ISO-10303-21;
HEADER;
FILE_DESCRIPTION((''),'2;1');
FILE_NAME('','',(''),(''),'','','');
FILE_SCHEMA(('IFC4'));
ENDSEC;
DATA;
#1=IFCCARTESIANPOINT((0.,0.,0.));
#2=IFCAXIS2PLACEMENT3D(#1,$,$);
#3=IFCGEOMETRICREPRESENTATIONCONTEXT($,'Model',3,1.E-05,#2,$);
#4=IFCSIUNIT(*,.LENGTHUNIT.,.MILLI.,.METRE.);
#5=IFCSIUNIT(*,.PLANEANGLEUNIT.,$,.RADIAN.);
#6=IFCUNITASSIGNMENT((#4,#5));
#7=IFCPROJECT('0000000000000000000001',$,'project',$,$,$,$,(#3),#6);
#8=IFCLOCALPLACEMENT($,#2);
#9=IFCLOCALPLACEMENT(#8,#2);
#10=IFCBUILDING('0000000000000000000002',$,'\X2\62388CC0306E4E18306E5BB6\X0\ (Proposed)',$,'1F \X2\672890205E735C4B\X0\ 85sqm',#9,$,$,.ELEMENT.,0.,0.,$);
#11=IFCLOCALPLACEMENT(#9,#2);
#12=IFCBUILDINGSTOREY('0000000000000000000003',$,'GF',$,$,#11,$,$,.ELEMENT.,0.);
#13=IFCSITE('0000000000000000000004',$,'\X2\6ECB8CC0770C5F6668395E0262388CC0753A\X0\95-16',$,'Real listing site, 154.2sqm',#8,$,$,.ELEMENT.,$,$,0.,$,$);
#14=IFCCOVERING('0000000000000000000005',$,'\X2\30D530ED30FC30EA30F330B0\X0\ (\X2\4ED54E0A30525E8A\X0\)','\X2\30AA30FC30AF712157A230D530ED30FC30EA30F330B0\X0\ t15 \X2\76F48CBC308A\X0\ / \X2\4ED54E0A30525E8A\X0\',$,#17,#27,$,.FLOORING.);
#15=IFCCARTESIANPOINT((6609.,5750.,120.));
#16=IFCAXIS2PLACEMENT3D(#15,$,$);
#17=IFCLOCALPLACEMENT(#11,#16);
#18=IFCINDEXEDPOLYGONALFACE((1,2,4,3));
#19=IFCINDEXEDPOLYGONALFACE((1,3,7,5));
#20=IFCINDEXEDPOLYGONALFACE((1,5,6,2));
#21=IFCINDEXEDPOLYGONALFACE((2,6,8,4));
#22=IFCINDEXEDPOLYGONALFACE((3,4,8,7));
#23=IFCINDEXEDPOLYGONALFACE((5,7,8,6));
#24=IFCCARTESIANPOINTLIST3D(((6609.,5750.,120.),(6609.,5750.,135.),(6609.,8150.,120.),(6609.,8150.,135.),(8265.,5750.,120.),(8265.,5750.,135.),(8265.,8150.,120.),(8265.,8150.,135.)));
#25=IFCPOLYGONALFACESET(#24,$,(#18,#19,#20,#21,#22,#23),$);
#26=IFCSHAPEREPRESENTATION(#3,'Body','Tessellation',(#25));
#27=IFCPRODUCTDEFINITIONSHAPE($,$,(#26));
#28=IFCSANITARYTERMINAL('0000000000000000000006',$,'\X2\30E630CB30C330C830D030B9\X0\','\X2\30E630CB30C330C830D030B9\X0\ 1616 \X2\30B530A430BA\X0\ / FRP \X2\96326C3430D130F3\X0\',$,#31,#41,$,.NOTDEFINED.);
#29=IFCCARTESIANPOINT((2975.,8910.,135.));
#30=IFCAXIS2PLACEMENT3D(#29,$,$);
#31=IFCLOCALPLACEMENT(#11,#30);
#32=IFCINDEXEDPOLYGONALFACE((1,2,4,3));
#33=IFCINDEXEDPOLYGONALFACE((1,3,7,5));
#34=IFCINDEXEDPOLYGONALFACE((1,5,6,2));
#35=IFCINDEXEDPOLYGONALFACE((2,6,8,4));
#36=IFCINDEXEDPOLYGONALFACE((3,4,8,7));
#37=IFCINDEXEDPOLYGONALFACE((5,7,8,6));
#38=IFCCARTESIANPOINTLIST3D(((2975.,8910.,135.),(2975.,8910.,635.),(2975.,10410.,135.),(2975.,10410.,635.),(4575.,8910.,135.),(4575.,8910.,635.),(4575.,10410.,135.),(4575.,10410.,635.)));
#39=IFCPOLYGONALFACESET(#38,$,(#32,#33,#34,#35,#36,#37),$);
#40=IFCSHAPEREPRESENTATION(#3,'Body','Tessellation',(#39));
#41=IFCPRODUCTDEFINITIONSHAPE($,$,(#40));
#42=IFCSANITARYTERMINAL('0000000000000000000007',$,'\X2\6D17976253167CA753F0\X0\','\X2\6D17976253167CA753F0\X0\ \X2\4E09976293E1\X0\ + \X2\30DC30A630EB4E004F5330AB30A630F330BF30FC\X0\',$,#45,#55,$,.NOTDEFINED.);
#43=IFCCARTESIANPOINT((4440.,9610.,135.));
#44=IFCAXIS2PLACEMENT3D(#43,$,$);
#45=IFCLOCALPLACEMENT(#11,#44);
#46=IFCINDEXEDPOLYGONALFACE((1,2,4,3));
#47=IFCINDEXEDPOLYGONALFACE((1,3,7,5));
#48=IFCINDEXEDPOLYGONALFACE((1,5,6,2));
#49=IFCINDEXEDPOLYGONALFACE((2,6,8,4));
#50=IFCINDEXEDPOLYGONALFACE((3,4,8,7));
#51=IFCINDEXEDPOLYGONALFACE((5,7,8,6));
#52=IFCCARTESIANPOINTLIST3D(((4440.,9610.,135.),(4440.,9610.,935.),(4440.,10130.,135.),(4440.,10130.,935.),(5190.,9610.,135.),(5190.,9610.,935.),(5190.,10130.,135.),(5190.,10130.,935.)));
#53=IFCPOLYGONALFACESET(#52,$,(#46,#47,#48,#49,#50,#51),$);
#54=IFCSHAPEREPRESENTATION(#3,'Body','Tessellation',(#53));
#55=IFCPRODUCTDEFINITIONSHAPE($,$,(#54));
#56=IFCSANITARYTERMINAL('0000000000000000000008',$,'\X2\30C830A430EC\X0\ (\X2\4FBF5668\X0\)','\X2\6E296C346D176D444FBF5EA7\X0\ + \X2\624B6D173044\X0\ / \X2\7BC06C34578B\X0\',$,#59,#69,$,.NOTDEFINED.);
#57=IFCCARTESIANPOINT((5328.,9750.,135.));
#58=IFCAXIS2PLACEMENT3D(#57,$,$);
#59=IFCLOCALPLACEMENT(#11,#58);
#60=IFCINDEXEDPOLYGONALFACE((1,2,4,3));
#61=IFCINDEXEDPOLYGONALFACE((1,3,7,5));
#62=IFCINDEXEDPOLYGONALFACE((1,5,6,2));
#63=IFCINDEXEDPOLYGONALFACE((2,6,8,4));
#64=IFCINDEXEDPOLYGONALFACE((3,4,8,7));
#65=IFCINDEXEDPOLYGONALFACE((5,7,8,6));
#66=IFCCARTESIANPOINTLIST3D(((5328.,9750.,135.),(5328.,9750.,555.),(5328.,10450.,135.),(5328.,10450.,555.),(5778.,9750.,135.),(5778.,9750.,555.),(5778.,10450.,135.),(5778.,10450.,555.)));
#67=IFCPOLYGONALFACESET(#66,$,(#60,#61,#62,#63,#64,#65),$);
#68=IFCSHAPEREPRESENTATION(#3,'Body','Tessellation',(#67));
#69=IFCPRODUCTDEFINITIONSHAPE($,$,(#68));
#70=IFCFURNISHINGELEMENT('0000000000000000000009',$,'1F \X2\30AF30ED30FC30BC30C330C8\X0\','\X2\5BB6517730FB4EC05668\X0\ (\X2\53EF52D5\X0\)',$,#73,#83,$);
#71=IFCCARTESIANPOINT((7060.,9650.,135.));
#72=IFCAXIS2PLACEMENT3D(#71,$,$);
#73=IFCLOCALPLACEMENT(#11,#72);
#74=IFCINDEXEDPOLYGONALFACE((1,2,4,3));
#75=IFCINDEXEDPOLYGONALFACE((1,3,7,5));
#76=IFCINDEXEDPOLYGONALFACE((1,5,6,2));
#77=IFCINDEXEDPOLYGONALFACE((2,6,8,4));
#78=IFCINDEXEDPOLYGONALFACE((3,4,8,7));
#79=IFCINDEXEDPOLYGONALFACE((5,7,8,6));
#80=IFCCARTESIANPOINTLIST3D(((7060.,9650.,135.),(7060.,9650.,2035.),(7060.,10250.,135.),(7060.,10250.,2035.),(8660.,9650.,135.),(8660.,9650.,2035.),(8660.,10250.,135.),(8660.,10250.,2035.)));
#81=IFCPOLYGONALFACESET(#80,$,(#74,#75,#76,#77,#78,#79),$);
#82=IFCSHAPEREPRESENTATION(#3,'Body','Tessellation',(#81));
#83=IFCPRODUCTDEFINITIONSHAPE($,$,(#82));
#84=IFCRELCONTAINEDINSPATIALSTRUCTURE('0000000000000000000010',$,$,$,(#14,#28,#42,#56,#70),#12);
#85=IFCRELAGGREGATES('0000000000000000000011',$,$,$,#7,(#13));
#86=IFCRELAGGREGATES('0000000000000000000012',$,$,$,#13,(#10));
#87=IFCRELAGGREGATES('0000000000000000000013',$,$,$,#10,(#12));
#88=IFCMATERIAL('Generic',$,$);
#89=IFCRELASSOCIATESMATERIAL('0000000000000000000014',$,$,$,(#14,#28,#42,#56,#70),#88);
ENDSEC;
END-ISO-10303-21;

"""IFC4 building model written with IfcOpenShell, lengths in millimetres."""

from ifc_helpers import new_model, si_unit, frame, frame_2d, origin, place, context, project, spatial, rectangle, extrude, material, element, save


model = new_model("IFC4")

# Units and contexts
model_context = context("Model", 3, precision=1e-05, world=origin())
ifc_project = project(units=[si_unit("LENGTHUNIT", "METRE", prefix="MILLI"), si_unit("PLANEANGLEUNIT", "RADIAN")], contexts=[model_context])

# Site, building, storey
site_placement = place(None, origin())
site = spatial("IfcSite", under=ifc_project, at=site_placement, Name="滋賀県彦根市戸賀町95-16", ObjectType="Real listing site, 154.2sqm", CompositionType="ELEMENT", RefElevation=0.0)
building_placement = place(site_placement, origin())
building = spatial("IfcBuilding", under=site, at=building_placement, Name="戸賀の丘の家 (Proposed)", ObjectType="1F 木造平屋 85sqm", CompositionType="ELEMENT", ElevationOfRefHeight=0.0, ElevationOfTerrain=0.0)
storey_placement = place(building_placement, origin())
storey = spatial("IfcBuildingStorey", under=building, at=storey_placement, Name="GF", CompositionType="ELEMENT", Elevation=0.0)

# Covering
ifc_material_1 = material(Name="Generic")
covering_1_placement = place(storey_placement, frame((6609.0, 5750.0, 120.0)))
element("IfcCovering", 1, at=covering_1_placement, inside=storey, material=ifc_material_1, Name="フローリング (仕上げ床)", Description="オーク無垢フローリング t15 直貼り / 仕上げ床", PredefinedType="FLOORING", context=model_context, shape_type="SweptSolid", body=[
    extrude(rectangle(XDim=1656.0, YDim=2400.0, at=frame_2d((828.0, 1200.0))), frame((6609.0, 5750.0, 120.0)), (0.0, 0.0, 1.0), 15.0),
])

# Sanitary terminals
sanitary_terminal_1_placement = place(storey_placement, frame((2975.0, 8910.0, 135.0)))
element("IfcSanitaryTerminal", 2, at=sanitary_terminal_1_placement, inside=storey, material=ifc_material_1, Name="ユニットバス", Description="ユニットバス 1616 サイズ / FRP 防水パン", PredefinedType="NOTDEFINED", context=model_context, shape_type="SweptSolid", body=[
    extrude(rectangle(XDim=1600.0, YDim=1500.0, at=frame_2d((800.0, 750.0))), frame((2975.0, 8910.0, 135.0)), (0.0, 0.0, 1.0), 500.0),
])
sanitary_terminal_2_placement = place(storey_placement, frame((4440.0, 9610.0, 135.0)))
element("IfcSanitaryTerminal", 3, at=sanitary_terminal_2_placement, inside=storey, material=ifc_material_1, Name="洗面化粧台", Description="洗面化粧台 三面鏡 + ボウル一体カウンター", PredefinedType="NOTDEFINED", context=model_context, shape_type="SweptSolid", body=[
    extrude(rectangle(XDim=750.0, YDim=520.0, at=frame_2d((375.0, 260.0))), frame((4440.0, 9610.0, 135.0)), (0.0, 0.0, 1.0), 800.0),
])
sanitary_terminal_3_placement = place(storey_placement, frame((5328.0, 9750.0, 135.0)))
element("IfcSanitaryTerminal", 4, at=sanitary_terminal_3_placement, inside=storey, material=ifc_material_1, Name="トイレ (便器)", Description="温水洗浄便座 + 手洗い / 節水型", PredefinedType="NOTDEFINED", context=model_context, shape_type="SweptSolid", body=[
    extrude(rectangle(XDim=450.0, YDim=700.0, at=frame_2d((225.0, 350.0))), frame((5328.0, 9750.0, 135.0)), (0.0, 0.0, 1.0), 420.0),
])

# Furnishing element
furnishing_placement = place(storey_placement, frame((7060.0, 9650.0, 135.0)))
element("IfcFurnishingElement", 5, at=furnishing_placement, inside=storey, material=ifc_material_1, Name="1F クローゼット", Description="家具・什器 (可動)", context=model_context, shape_type="SweptSolid", body=[
    extrude(rectangle(XDim=1600.0, YDim=600.0, at=frame_2d((800.0, 300.0))), frame((7060.0, 9650.0, 135.0)), (0.0, 0.0, 1.0), 1900.0),
])

save(model, "model.ifc")
